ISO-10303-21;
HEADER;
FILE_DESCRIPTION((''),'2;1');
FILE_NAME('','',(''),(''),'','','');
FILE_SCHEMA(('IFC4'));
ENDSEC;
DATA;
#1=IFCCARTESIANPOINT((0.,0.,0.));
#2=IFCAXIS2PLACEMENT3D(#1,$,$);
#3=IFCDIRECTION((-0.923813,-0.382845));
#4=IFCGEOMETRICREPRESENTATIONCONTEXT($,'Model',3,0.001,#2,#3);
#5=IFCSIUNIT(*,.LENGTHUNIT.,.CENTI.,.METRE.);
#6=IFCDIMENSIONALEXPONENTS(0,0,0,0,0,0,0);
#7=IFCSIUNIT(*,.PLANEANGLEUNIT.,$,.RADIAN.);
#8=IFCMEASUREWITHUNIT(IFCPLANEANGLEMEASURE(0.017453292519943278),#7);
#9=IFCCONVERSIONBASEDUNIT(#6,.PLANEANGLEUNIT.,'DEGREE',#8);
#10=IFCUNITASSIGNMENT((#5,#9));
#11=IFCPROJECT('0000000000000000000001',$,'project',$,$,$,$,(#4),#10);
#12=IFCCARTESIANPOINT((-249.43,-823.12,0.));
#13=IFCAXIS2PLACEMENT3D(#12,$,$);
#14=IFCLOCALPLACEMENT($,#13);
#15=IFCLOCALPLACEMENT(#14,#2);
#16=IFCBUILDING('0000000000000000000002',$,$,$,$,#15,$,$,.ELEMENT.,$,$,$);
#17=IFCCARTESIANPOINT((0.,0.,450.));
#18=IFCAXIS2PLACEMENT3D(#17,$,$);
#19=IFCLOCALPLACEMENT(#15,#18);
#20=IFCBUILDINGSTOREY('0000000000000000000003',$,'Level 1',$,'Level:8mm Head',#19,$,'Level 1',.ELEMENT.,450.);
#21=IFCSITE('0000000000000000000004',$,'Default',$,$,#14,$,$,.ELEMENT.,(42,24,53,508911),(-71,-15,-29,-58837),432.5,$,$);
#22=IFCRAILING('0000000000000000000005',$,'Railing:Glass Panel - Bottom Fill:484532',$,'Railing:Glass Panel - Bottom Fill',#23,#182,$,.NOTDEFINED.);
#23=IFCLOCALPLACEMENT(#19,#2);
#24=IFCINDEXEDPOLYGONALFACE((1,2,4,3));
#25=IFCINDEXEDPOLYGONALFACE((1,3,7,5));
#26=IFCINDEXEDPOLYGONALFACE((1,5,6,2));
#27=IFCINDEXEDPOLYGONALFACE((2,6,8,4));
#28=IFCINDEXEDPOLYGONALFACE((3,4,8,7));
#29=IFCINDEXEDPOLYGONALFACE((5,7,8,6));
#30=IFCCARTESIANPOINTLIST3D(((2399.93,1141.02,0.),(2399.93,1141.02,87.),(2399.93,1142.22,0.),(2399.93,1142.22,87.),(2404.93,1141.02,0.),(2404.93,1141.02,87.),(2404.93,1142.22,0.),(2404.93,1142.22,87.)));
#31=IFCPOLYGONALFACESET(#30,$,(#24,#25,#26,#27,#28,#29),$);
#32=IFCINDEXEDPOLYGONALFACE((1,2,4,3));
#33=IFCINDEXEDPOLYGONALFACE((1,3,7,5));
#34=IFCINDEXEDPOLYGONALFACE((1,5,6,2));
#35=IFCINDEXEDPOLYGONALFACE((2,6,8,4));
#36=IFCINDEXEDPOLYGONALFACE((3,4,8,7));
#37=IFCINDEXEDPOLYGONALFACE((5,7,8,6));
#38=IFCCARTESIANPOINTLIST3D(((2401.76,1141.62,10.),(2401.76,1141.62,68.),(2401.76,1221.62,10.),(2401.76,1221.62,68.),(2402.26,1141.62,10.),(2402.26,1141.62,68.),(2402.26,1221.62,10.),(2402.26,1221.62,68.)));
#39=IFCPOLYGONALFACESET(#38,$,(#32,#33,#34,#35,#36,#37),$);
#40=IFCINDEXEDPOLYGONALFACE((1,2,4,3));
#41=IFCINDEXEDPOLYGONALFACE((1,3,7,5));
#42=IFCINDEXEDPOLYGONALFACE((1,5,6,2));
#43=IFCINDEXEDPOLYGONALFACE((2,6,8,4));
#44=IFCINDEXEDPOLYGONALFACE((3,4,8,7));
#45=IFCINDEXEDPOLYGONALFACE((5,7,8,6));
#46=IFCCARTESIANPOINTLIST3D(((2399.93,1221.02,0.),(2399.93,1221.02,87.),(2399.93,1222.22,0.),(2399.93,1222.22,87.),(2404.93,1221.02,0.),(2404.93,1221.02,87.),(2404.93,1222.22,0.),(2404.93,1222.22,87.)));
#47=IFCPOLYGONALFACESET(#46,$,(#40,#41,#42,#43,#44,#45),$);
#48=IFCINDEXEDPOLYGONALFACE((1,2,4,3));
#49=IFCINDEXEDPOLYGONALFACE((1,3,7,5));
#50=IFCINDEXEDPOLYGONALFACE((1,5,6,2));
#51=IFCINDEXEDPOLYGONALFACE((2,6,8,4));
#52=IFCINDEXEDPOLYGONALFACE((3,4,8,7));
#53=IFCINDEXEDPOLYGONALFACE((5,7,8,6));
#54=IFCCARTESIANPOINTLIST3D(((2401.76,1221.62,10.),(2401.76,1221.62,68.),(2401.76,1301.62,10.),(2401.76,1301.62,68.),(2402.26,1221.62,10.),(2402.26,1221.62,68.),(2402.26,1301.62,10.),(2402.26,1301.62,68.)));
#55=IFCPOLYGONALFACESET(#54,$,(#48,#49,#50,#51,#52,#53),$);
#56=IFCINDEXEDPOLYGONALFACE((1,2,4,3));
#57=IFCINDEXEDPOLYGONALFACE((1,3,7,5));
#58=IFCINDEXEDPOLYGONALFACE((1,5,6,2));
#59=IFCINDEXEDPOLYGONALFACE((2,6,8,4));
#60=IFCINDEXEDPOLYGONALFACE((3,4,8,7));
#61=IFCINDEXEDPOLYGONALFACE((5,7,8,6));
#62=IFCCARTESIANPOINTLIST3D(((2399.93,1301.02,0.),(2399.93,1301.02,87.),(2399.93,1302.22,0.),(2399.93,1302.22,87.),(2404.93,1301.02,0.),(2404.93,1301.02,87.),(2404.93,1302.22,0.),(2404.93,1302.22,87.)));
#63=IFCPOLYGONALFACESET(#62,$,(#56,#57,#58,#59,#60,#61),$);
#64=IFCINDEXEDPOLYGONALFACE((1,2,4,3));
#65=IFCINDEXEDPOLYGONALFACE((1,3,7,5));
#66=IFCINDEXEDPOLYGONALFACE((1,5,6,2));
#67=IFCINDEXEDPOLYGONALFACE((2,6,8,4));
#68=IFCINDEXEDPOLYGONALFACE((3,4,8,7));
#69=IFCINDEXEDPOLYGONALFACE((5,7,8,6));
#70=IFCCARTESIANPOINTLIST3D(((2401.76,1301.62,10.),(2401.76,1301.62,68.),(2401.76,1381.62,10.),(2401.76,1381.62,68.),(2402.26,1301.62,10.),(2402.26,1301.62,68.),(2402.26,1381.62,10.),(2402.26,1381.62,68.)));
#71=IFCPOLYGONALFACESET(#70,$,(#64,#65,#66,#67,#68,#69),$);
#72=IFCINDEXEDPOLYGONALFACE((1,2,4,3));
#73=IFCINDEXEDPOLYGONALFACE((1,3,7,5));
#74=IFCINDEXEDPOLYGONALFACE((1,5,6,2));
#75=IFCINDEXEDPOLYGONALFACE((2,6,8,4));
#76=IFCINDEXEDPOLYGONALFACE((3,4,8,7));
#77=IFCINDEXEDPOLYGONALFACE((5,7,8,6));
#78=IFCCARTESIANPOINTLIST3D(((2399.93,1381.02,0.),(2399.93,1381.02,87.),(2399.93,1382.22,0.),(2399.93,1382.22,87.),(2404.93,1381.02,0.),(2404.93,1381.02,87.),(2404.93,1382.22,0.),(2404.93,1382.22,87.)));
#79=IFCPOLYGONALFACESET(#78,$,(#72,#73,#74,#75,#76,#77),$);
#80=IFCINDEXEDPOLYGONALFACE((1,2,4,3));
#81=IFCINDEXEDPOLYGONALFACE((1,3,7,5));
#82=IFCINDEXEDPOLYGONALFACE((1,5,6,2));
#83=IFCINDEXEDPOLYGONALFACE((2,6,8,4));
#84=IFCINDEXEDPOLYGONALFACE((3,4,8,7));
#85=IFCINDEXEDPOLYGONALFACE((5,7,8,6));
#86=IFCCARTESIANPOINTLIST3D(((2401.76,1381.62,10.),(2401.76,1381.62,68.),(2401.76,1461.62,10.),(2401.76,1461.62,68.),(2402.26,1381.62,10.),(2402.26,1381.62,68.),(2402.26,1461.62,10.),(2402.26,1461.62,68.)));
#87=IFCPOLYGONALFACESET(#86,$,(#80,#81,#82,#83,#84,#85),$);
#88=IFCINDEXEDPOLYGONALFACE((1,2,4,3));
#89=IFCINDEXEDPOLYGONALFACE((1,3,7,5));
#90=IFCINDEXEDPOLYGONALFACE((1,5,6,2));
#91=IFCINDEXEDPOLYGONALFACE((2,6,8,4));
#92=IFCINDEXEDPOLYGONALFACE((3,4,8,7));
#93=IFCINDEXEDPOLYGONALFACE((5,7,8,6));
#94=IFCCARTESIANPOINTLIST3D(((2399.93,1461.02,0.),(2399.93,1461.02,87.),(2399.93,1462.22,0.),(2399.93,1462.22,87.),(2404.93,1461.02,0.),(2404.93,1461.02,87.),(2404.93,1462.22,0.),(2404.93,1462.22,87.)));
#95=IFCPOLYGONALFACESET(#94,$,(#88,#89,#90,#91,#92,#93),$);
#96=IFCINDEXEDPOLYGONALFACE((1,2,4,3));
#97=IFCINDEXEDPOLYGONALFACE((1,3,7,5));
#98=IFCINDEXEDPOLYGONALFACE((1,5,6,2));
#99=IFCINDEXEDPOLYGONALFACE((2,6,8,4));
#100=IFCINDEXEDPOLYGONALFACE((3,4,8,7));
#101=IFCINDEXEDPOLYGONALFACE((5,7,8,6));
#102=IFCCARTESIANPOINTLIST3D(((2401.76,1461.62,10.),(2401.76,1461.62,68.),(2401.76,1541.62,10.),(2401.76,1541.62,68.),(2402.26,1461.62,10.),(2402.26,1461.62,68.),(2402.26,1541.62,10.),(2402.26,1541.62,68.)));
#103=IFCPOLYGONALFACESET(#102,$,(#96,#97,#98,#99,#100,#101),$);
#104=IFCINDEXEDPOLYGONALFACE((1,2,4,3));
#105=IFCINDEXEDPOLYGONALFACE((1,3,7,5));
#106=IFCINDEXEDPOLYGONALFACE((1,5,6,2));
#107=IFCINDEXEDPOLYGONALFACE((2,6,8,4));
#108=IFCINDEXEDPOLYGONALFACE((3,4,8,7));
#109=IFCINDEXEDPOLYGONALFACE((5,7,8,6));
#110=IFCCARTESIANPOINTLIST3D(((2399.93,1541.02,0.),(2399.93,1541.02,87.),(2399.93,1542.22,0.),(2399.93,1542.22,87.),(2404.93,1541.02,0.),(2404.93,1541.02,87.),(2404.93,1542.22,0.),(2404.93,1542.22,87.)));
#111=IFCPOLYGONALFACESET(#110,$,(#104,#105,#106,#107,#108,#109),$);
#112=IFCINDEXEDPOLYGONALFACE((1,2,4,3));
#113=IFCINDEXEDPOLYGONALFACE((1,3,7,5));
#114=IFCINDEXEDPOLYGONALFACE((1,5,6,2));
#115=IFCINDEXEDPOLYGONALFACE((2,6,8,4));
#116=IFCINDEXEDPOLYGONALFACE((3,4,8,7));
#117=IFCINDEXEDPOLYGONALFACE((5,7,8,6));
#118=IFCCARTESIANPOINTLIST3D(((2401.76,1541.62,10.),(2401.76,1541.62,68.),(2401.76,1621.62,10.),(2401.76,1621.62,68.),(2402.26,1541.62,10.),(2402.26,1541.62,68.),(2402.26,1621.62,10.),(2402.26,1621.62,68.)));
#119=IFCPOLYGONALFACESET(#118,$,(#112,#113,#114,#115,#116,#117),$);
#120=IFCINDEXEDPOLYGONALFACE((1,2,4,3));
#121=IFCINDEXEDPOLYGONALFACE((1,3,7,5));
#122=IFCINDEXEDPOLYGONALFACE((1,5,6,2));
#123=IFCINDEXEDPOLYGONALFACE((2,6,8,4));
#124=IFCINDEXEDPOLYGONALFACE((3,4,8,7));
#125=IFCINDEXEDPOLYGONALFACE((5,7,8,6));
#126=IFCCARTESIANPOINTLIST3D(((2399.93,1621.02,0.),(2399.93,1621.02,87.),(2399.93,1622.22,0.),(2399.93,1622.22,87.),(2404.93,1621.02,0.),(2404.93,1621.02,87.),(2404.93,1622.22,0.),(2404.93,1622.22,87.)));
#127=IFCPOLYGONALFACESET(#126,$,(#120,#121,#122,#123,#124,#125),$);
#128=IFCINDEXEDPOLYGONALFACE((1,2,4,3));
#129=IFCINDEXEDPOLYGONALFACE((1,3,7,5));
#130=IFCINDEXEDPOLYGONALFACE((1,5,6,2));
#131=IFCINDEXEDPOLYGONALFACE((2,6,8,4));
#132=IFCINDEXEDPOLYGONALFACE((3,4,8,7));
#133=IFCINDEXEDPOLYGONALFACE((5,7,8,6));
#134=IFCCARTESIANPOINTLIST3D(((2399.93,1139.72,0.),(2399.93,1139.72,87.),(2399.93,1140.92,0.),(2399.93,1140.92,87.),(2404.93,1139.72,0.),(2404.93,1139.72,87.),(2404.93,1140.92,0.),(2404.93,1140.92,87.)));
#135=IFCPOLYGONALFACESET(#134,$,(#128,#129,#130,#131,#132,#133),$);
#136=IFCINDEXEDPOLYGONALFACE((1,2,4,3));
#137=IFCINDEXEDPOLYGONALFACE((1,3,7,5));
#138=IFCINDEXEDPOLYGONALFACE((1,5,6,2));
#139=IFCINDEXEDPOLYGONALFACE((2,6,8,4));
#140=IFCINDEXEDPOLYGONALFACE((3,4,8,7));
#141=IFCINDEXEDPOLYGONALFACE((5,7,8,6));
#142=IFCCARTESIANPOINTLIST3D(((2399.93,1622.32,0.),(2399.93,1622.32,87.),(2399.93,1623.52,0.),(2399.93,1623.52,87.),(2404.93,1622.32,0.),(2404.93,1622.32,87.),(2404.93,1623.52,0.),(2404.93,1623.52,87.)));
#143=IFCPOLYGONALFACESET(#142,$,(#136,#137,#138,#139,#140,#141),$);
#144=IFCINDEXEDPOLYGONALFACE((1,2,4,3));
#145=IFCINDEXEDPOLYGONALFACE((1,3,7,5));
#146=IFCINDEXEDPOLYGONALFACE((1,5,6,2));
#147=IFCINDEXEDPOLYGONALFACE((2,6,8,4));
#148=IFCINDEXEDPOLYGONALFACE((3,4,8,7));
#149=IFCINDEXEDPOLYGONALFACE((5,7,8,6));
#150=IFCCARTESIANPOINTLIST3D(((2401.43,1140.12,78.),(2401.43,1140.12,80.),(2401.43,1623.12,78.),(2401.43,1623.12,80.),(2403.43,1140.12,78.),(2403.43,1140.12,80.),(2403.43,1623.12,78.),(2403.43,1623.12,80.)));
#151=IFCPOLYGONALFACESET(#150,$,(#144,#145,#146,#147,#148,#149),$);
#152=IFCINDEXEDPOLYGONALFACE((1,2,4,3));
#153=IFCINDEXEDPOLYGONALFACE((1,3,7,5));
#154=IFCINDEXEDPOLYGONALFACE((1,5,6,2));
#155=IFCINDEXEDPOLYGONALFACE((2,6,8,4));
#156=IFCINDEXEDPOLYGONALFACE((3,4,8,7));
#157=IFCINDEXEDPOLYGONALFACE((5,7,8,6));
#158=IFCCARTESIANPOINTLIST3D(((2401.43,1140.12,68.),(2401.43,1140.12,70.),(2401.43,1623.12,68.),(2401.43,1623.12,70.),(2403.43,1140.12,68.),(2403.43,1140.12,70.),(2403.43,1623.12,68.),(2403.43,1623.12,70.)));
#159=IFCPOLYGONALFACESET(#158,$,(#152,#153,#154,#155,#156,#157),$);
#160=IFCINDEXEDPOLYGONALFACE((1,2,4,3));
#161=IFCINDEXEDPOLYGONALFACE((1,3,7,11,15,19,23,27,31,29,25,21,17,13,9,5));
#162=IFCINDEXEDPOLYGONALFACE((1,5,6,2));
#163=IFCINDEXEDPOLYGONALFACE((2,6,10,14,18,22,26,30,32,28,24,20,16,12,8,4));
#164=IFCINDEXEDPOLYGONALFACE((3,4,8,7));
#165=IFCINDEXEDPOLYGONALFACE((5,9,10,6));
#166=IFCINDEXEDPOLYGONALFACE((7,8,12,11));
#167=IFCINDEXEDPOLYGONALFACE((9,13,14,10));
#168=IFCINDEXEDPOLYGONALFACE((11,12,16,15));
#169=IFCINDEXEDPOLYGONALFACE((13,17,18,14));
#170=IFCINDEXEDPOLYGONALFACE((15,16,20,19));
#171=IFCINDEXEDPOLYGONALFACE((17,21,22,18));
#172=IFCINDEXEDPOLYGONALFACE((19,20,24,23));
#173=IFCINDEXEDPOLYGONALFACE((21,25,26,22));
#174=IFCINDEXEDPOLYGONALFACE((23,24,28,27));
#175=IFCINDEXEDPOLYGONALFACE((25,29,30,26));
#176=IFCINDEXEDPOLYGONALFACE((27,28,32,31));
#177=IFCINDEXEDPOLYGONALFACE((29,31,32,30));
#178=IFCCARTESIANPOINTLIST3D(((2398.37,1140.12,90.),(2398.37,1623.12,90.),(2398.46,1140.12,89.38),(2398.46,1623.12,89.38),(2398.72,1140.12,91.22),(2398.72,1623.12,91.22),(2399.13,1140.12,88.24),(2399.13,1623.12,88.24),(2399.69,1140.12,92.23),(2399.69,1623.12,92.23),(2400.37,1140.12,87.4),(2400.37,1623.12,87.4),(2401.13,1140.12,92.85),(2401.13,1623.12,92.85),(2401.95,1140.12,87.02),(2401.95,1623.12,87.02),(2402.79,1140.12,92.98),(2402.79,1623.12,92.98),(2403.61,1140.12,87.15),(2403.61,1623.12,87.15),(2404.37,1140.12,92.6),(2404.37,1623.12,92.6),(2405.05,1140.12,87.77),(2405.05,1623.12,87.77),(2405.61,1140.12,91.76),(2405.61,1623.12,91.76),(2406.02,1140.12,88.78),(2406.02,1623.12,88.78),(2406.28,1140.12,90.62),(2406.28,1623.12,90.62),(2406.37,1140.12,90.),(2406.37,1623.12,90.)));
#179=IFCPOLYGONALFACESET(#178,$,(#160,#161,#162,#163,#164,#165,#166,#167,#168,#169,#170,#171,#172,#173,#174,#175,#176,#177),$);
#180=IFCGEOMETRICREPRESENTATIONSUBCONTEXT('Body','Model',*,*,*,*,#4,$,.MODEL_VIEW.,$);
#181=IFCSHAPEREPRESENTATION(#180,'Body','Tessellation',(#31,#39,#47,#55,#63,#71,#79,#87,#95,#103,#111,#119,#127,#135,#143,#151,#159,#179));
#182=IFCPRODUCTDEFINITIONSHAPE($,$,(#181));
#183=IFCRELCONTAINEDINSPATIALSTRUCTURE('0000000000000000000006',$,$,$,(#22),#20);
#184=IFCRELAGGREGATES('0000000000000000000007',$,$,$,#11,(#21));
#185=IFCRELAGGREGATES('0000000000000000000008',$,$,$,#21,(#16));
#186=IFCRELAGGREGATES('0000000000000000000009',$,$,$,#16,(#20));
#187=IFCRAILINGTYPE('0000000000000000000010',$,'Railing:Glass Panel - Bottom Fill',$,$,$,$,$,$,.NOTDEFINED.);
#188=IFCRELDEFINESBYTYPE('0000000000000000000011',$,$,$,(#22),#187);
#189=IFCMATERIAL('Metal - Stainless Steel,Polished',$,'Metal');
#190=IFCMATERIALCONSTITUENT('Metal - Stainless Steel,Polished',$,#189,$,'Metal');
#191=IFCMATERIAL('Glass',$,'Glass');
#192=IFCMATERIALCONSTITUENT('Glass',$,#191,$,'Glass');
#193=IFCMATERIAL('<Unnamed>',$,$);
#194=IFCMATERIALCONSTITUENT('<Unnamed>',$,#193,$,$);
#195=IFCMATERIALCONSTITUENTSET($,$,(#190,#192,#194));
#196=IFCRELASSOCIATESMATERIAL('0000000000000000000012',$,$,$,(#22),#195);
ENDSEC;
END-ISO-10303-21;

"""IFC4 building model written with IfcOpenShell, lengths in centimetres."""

from ifc_helpers import new_model, entity, si_unit, converted_unit, direction, frame, origin, place, context, subcontext, project, spatial, indexed_curve, outline, extrude, material, constituent, constituent_set, type_object, element, save


model = new_model("IFC4")

# Units and contexts
model_context = context("Model", 3, precision=0.001, world=origin(), true_north=direction((-0.923813, -0.382845)))
body_context = subcontext(model_context, "Body", "Model", "MODEL_VIEW")
ifc_project = project(units=[si_unit("LENGTHUNIT", "METRE", prefix="CENTI"), converted_unit("PLANEANGLEUNIT", "DEGREE", entity("IfcPlaneAngleMeasure", 0.017453292519943278), si_unit("PLANEANGLEUNIT", "RADIAN"), dimensions=[0, 0, 0, 0, 0, 0, 0])], contexts=[model_context])

# Site, building, storey
site_placement = place(None, frame((-249.43, -823.12, 0.0)))
site = spatial("IfcSite", under=ifc_project, at=site_placement, Name="Default", CompositionType="ELEMENT", RefLatitude=(42, 24, 53, 508911), RefLongitude=(-71, -15, -29, -58837), RefElevation=432.5)
building_placement = place(site_placement, origin())
building = spatial("IfcBuilding", under=site, at=building_placement, CompositionType="ELEMENT")
storey_placement = place(building_placement, frame((0.0, 0.0, 450.0)))
storey = spatial("IfcBuildingStorey", under=building, at=storey_placement, Name="Level 1", ObjectType="Level:8mm Head", LongName="Level 1", CompositionType="ELEMENT", Elevation=450.0)

# Shared definitions
ifc_material_1 = material(Name="<Unnamed>")

# Shared definitions
ifc_material_2 = material(Name="Glass", Category="Glass")

# Railing
ifc_material_3 = material(Name="Metal - Stainless Steel,Polished", Category="Metal")
ifc_constituent_1 = constituent(ifc_material_3, Name="Metal - Stainless Steel,Polished", Category="Metal")
ifc_constituent_2 = constituent(ifc_material_2, Name="Glass", Category="Glass")
ifc_constituent_3 = constituent(ifc_material_1, Name="<Unnamed>")
ifc_constituent_set_1 = constituent_set(constituents=[ifc_constituent_1, ifc_constituent_2, ifc_constituent_3])
railing_type = type_object("IfcRailingType", Name="Railing:Glass Panel - Bottom Fill", PredefinedType="NOTDEFINED")
railing_placement = place(storey_placement, origin())
element("IfcRailing", 1, at=railing_placement, inside=storey, type_object=railing_type, material=ifc_constituent_set_1, Name="Railing:Glass Panel - Bottom Fill:484532", ObjectType="Railing:Glass Panel - Bottom Fill", PredefinedType="NOTDEFINED", context=body_context, shape_type="SweptSolid", body=[
    extrude(outline(indexed_curve([(-2.5, -0.6), (2.5, -0.6), (2.5, 0.6), (-2.5, 0.6), (-2.5, -0.6)], self_intersect=False)), frame((2402.43, 1141.62, 0.0), z_axis=(0.0, 0.0, 1.0), x_axis=(-1.0, 0.0, 0.0)), (0.0, 0.0, 1.0), 87.0),
    extrude(outline(indexed_curve([(-0.25, -40.0), (0.25, -40.0), (0.25, 40.0), (-0.25, 40.0), (-0.25, -40.0)], self_intersect=False)), frame((2402.01, 1181.62, 10.0), z_axis=(0.0, 0.0, 1.0), x_axis=(-1.0, 0.0, 0.0)), (0.0, 0.0, 1.0), 58.0),
    extrude(outline(indexed_curve([(-2.5, -0.6), (2.5, -0.6), (2.5, 0.6), (-2.5, 0.6), (-2.5, -0.6)], self_intersect=False)), frame((2402.43, 1221.62, 0.0), z_axis=(0.0, 0.0, 1.0), x_axis=(-1.0, 0.0, 0.0)), (0.0, 0.0, 1.0), 87.0),
    extrude(outline(indexed_curve([(-0.25, -40.0), (0.25, -40.0), (0.25, 40.0), (-0.25, 40.0), (-0.25, -40.0)], self_intersect=False)), frame((2402.01, 1261.62, 10.0), z_axis=(0.0, 0.0, 1.0), x_axis=(-1.0, 0.0, 0.0)), (0.0, 0.0, 1.0), 58.0),
    extrude(outline(indexed_curve([(-2.5, -0.6), (2.5, -0.6), (2.5, 0.6), (-2.5, 0.6), (-2.5, -0.6)], self_intersect=False)), frame((2402.43, 1301.62, 0.0), z_axis=(0.0, 0.0, 1.0), x_axis=(-1.0, 0.0, 0.0)), (0.0, 0.0, 1.0), 87.0),
    extrude(outline(indexed_curve([(-0.25, -40.0), (0.25, -40.0), (0.25, 40.0), (-0.25, 40.0), (-0.25, -40.0)], self_intersect=False)), frame((2402.01, 1341.62, 10.0), z_axis=(0.0, 0.0, 1.0), x_axis=(-1.0, 0.0, 0.0)), (0.0, 0.0, 1.0), 58.0),
    extrude(outline(indexed_curve([(-2.5, -0.6), (2.5, -0.6), (2.5, 0.6), (-2.5, 0.6), (-2.5, -0.6)], self_intersect=False)), frame((2402.43, 1381.62, 0.0), z_axis=(0.0, 0.0, 1.0), x_axis=(-1.0, 0.0, 0.0)), (0.0, 0.0, 1.0), 87.0),
    extrude(outline(indexed_curve([(-0.25, -40.0), (0.25, -40.0), (0.25, 40.0), (-0.25, 40.0), (-0.25, -40.0)], self_intersect=False)), frame((2402.01, 1421.62, 10.0), z_axis=(0.0, 0.0, 1.0), x_axis=(-1.0, 0.0, 0.0)), (0.0, 0.0, 1.0), 58.0),
    extrude(outline(indexed_curve([(-2.5, -0.6), (2.5, -0.6), (2.5, 0.6), (-2.5, 0.6), (-2.5, -0.6)], self_intersect=False)), frame((2402.43, 1461.62, 0.0), z_axis=(0.0, 0.0, 1.0), x_axis=(-1.0, 0.0, 0.0)), (0.0, 0.0, 1.0), 87.0),
    extrude(outline(indexed_curve([(-0.25, -40.0), (0.25, -40.0), (0.25, 40.0), (-0.25, 40.0), (-0.25, -40.0)], self_intersect=False)), frame((2402.01, 1501.62, 10.0), z_axis=(0.0, 0.0, 1.0), x_axis=(-1.0, 0.0, 0.0)), (0.0, 0.0, 1.0), 58.0),
    extrude(outline(indexed_curve([(-2.5, -0.6), (2.5, -0.6), (2.5, 0.6), (-2.5, 0.6), (-2.5, -0.6)], self_intersect=False)), frame((2402.43, 1541.62, 0.0), z_axis=(0.0, 0.0, 1.0), x_axis=(-1.0, 0.0, 0.0)), (0.0, 0.0, 1.0), 87.0),
    extrude(outline(indexed_curve([(-0.25, -40.0), (0.25, -40.0), (0.25, 40.0), (-0.25, 40.0), (-0.25, -40.0)], self_intersect=False)), frame((2402.01, 1581.62, 10.0), z_axis=(0.0, 0.0, 1.0), x_axis=(-1.0, 0.0, 0.0)), (0.0, 0.0, 1.0), 58.0),
    extrude(outline(indexed_curve([(-2.5, -0.6), (2.5, -0.6), (2.5, 0.6), (-2.5, 0.6), (-2.5, -0.6)], self_intersect=False)), frame((2402.43, 1621.62, 0.0), z_axis=(0.0, 0.0, 1.0), x_axis=(-1.0, 0.0, 0.0)), (0.0, 0.0, 1.0), 87.0),
    extrude(outline(indexed_curve([(-2.5, -0.6), (2.5, -0.6), (2.5, 0.6), (-2.5, 0.6), (-2.5, -0.6)], self_intersect=False)), frame((2402.43, 1140.32, 0.0), z_axis=(0.0, 0.0, 1.0), x_axis=(-1.0, 0.0, 0.0)), (0.0, 0.0, 1.0), 87.0),
    extrude(outline(indexed_curve([(-2.5, -0.6), (2.5, -0.6), (2.5, 0.6), (-2.5, 0.6), (-2.5, -0.6)], self_intersect=False)), frame((2402.43, 1622.92, 0.0), z_axis=(0.0, 0.0, 1.0), x_axis=(-1.0, 0.0, 0.0)), (0.0, 0.0, 1.0), 87.0),
    extrude(outline(indexed_curve([(-241.5, -1.0), (241.5, -1.0), (241.5, 1.0), (-241.5, 1.0), (-241.5, -1.0)], self_intersect=False)), frame((2402.43, 1381.62, 78.0), z_axis=(0.0, 0.0, 1.0), x_axis=(0.0, -1.0, 0.0)), (0.0, 0.0, 1.0), 2.0),
    extrude(outline(indexed_curve([(-241.5, -1.0), (241.5, -1.0), (241.5, 1.0), (-241.5, 1.0), (-241.5, -1.0)], self_intersect=False)), frame((2402.43, 1381.62, 68.0), z_axis=(0.0, 0.0, 1.0), x_axis=(0.0, -1.0, 0.0)), (0.0, 0.0, 1.0), 2.0),
    extrude(outline(indexed_curve([(-1.09, -3.85), (0.18, -3.85), (1.42, -3.18), (2.41, -1.97), (2.98, -0.41), (3.04, 1.22), (2.58, 2.63), (1.67, 3.59), (1.09, 3.85), (-0.18, 3.85), (-1.42, 3.18), (-2.41, 1.97), (-2.98, 0.41), (-3.04, -1.22), (-2.58, -2.63), (-1.67, -3.59), (-1.09, -3.85)], self_intersect=False)), frame((2402.37, 1140.12, 90.0), z_axis=(0.0, 1.0, 0.0), x_axis=(-0.27267, 0.0, -0.962108)), (0.0, 0.0, 1.0), 483.0),
])

save(model, "model.ifc")
